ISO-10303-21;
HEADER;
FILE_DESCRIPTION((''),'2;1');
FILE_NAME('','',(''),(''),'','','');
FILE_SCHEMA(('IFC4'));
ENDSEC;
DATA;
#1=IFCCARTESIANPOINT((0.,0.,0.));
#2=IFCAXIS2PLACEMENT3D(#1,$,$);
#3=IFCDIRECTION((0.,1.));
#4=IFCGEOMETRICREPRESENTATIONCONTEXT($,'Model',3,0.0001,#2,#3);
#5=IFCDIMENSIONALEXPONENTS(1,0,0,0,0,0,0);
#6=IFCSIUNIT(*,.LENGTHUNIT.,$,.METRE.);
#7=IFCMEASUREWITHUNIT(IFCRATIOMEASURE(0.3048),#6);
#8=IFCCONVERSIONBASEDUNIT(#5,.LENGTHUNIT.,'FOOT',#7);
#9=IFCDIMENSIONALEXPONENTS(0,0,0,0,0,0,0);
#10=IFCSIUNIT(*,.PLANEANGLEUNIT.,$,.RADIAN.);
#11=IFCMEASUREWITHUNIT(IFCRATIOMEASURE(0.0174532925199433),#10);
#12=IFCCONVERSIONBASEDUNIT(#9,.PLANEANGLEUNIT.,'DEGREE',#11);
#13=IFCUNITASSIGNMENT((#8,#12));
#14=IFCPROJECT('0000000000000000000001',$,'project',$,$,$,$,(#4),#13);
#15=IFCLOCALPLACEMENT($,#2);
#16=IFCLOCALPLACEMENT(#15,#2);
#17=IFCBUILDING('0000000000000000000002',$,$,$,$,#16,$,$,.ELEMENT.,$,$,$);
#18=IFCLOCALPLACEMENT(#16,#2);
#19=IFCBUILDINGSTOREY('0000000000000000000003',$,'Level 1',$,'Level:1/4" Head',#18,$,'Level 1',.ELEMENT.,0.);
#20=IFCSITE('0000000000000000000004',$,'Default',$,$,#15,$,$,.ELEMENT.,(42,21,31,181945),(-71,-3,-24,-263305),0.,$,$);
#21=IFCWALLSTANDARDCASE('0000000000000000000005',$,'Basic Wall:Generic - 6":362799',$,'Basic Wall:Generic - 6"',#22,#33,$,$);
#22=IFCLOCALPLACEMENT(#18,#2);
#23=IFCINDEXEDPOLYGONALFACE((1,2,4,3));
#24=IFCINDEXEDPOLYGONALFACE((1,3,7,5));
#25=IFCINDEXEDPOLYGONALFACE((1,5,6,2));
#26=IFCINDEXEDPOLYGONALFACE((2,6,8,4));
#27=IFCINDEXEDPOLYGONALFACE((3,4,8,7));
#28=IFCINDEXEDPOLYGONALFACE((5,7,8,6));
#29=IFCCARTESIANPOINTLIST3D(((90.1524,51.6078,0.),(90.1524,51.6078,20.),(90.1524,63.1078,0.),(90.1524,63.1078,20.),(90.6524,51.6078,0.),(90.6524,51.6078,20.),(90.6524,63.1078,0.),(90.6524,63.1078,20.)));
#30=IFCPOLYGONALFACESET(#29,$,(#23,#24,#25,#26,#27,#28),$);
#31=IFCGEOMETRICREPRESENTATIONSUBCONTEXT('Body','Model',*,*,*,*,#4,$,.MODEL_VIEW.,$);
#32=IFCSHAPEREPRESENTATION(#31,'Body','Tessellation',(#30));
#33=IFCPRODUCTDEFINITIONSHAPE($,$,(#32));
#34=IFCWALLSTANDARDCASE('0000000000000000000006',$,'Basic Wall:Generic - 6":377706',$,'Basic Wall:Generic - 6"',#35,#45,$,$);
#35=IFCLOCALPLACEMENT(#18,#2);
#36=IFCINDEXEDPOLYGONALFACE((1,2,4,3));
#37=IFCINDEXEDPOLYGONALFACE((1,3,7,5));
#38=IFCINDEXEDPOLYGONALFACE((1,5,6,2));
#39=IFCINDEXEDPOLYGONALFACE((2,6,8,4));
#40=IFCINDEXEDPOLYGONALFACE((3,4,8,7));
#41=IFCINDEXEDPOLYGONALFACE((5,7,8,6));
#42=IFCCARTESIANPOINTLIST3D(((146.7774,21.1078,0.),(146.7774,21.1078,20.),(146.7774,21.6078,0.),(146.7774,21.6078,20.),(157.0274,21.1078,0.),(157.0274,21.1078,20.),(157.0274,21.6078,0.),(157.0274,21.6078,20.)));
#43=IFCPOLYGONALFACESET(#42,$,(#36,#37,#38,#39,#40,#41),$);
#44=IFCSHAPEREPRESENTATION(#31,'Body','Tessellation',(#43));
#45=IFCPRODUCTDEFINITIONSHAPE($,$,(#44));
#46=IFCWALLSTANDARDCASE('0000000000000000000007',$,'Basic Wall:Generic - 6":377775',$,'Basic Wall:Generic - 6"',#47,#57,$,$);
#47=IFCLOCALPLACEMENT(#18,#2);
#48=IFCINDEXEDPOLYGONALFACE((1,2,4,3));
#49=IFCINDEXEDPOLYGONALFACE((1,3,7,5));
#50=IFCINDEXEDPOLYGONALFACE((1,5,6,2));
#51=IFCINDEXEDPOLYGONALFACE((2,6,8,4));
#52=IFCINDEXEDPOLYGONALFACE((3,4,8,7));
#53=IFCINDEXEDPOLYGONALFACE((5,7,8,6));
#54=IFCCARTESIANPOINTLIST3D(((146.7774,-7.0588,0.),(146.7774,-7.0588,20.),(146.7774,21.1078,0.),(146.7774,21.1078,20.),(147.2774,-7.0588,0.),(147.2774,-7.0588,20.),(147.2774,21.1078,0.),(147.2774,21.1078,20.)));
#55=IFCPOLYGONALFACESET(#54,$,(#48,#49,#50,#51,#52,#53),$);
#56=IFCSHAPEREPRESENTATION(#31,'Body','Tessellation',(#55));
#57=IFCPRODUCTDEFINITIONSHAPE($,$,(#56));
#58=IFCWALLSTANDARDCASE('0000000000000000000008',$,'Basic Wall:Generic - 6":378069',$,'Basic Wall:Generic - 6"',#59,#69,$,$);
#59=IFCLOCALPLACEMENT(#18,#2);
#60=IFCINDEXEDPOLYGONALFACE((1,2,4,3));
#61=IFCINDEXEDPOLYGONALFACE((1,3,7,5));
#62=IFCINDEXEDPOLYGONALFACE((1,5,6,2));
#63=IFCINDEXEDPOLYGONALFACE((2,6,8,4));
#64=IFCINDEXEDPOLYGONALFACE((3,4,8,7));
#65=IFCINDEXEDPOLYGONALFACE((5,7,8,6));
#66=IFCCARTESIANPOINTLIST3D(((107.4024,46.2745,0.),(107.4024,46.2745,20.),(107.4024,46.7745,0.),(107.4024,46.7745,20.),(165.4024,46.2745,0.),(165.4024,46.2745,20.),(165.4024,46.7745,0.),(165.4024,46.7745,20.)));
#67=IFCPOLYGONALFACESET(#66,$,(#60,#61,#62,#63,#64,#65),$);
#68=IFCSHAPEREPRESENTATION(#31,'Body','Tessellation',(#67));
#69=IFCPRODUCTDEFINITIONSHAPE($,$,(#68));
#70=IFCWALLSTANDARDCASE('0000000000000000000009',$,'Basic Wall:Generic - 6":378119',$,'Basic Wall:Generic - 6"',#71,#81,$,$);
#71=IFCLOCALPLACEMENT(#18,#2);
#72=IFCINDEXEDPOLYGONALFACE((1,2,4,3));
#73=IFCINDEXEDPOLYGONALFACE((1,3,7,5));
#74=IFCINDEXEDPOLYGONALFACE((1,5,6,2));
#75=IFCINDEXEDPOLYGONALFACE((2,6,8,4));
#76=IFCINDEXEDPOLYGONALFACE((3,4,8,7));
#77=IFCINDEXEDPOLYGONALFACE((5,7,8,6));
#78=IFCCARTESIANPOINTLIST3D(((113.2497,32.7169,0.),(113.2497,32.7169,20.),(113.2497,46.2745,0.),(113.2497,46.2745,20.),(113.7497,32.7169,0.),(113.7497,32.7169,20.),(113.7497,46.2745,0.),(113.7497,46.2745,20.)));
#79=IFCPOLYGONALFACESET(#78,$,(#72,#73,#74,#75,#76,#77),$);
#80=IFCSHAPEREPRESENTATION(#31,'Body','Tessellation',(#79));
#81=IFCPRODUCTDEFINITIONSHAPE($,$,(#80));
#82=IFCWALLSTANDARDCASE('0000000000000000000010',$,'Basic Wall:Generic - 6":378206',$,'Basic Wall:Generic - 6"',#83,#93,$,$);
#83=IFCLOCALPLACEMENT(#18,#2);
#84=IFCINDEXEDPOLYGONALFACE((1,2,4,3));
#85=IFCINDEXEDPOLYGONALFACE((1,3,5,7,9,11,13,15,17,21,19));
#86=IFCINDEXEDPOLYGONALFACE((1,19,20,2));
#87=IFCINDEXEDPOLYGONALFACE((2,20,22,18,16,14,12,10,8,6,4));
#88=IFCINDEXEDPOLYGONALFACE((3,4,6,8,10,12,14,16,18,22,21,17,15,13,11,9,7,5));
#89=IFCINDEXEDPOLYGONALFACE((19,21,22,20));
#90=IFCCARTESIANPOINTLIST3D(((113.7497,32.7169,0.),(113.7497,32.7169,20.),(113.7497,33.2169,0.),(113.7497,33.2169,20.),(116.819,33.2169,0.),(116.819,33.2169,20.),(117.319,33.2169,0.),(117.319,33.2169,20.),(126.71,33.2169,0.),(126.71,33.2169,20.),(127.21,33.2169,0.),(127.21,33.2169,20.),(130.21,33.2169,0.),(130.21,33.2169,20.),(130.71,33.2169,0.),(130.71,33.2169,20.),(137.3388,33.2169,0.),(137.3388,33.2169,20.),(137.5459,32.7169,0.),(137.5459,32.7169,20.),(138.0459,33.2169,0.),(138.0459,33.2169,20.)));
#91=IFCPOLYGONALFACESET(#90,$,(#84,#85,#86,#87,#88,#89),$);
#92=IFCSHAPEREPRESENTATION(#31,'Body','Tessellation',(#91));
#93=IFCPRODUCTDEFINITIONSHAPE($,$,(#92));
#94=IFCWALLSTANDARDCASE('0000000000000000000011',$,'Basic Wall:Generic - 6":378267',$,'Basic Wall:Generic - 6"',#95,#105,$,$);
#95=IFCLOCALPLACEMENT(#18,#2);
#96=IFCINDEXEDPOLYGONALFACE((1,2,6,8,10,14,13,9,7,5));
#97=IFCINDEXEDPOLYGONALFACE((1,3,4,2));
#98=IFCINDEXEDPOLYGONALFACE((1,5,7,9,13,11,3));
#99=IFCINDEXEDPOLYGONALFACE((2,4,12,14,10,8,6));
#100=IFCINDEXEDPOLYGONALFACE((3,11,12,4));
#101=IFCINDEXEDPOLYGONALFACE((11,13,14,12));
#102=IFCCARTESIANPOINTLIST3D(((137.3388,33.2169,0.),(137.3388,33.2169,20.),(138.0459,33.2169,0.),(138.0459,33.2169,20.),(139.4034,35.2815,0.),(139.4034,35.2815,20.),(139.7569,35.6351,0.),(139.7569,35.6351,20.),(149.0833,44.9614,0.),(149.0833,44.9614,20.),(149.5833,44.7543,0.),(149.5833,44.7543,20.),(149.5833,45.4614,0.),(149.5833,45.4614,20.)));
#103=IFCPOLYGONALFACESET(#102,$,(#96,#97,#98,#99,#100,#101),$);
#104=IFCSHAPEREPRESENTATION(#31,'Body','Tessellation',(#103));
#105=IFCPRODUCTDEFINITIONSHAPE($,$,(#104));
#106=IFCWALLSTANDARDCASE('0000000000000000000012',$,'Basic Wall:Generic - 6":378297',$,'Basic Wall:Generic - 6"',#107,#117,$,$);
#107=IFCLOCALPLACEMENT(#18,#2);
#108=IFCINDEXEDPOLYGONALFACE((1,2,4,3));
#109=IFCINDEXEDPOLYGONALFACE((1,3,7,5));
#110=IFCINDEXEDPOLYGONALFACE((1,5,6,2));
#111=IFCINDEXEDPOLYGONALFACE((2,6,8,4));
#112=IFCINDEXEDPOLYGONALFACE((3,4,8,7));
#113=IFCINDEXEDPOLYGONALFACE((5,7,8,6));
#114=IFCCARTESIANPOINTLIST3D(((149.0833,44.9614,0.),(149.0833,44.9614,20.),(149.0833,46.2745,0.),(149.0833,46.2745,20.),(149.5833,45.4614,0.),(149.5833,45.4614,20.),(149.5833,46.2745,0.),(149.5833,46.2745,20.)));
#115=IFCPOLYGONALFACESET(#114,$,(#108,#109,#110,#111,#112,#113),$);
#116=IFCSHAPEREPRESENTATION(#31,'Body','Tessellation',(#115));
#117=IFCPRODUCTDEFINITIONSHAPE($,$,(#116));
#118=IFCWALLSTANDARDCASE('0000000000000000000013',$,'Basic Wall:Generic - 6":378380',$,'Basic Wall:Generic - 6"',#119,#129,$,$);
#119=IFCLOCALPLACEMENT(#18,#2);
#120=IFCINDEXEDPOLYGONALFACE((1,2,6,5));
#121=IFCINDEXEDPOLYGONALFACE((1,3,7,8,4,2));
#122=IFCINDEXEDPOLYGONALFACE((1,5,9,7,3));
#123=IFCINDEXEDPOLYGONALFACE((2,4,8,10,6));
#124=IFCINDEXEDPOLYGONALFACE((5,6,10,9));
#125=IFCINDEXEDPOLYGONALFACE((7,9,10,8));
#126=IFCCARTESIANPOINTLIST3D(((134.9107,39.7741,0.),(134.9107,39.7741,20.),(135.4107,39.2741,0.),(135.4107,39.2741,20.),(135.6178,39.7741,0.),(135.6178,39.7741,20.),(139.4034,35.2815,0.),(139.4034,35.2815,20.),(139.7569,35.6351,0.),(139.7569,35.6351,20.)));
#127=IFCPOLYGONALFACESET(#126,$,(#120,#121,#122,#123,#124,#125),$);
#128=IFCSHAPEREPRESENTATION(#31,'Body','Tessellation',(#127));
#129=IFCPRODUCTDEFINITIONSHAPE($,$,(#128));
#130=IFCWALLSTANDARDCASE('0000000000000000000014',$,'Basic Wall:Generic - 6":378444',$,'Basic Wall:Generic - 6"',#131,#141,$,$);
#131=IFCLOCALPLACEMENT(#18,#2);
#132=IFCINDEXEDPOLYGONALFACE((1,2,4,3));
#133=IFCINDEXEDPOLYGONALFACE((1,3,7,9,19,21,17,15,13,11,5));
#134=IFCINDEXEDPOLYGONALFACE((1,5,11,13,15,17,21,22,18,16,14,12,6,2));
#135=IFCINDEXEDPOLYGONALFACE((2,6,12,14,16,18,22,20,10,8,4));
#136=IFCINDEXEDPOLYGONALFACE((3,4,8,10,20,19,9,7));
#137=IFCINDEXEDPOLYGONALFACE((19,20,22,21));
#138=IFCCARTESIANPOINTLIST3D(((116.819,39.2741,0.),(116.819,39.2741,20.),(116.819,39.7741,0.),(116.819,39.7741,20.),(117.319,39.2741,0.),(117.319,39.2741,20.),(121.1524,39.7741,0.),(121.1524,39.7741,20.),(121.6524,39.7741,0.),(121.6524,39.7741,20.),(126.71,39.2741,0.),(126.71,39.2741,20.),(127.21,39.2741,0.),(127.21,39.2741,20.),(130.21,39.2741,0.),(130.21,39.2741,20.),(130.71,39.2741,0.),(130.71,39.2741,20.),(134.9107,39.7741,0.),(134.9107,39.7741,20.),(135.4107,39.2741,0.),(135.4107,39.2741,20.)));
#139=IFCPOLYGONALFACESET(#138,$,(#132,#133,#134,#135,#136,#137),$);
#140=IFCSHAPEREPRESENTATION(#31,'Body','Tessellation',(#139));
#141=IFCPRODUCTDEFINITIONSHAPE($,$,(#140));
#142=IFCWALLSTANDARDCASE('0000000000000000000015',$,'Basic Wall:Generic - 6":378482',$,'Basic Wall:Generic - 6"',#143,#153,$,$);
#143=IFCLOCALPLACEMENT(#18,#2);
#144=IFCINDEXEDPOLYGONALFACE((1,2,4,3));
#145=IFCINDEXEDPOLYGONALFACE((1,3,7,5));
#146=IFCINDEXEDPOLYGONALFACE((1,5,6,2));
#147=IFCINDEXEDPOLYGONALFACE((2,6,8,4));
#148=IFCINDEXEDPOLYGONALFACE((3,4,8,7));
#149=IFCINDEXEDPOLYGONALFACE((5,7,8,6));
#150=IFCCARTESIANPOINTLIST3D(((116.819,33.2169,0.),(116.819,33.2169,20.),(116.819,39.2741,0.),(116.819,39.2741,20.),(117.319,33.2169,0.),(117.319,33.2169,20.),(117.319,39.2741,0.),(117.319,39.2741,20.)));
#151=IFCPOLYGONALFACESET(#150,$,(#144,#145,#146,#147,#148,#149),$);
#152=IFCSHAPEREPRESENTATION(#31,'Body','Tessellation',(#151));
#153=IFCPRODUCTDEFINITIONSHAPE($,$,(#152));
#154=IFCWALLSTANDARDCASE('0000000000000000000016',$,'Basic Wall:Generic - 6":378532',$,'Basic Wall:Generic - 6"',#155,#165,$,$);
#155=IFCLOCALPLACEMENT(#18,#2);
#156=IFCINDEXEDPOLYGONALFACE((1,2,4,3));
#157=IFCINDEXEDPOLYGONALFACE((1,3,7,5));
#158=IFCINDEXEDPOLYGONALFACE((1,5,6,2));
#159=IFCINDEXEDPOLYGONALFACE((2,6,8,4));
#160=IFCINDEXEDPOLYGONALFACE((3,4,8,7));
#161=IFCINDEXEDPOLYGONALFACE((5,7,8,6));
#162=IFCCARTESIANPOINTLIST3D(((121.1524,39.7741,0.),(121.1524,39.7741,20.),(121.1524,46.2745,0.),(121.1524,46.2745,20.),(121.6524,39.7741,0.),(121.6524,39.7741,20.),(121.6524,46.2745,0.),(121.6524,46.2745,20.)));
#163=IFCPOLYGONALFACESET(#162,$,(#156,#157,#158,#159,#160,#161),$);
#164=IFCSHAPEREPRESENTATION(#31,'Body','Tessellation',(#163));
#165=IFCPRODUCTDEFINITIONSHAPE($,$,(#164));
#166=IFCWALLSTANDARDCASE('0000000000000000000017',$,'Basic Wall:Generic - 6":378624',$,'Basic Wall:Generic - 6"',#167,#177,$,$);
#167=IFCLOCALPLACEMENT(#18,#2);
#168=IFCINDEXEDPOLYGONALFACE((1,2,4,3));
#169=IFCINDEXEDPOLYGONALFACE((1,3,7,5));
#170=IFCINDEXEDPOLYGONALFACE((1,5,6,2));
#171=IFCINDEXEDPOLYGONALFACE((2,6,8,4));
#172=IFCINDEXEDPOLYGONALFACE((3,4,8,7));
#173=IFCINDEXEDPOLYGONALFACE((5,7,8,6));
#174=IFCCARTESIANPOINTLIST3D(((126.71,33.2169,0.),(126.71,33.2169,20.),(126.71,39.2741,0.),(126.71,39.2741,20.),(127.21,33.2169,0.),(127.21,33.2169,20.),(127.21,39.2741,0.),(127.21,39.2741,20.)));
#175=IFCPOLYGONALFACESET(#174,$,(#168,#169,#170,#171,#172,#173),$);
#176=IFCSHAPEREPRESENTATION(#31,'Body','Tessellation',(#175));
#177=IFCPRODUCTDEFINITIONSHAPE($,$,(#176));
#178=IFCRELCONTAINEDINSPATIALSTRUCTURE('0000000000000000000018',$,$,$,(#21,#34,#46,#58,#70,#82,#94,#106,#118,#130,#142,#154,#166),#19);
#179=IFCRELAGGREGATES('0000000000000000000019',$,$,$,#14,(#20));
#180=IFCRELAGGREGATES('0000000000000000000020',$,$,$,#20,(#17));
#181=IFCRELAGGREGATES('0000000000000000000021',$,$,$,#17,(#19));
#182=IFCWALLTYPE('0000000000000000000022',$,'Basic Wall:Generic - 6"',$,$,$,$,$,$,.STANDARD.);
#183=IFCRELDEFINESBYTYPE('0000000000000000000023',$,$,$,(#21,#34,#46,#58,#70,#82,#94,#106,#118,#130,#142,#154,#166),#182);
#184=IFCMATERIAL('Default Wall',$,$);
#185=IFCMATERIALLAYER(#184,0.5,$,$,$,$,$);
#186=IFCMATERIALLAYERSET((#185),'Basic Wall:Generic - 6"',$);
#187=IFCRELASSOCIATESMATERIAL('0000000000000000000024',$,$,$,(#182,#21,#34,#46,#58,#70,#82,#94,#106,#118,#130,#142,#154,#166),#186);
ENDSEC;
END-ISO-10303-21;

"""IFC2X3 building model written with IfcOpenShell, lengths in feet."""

from ifc_helpers import new_model, entity, si_unit, converted_unit, direction, frame, frame_2d, origin, place, context, subcontext, project, spatial, polyline, rectangle, outline, extrude, material, layer, layer_set, layer_usage, type_object, element, save


model = new_model("IFC2X3")

# Units and contexts
model_context = context("Model", 3, precision=0.0001, world=origin(), true_north=direction((0.0, 1.0)))
body_context = subcontext(model_context, "Body", "Model", "MODEL_VIEW")
ifc_project = project(units=[converted_unit("LENGTHUNIT", "FOOT", entity("IfcRatioMeasure", 0.3048), si_unit("LENGTHUNIT", "METRE"), dimensions=[1, 0, 0, 0, 0, 0, 0]), converted_unit("PLANEANGLEUNIT", "DEGREE", entity("IfcRatioMeasure", 0.0174532925199433), si_unit("PLANEANGLEUNIT", "RADIAN"), dimensions=[0, 0, 0, 0, 0, 0, 0])], contexts=[model_context])

# Site, building, storey
site_placement = place(None, origin())
site = spatial("IfcSite", under=ifc_project, at=site_placement, Name="Default", CompositionType="ELEMENT", RefLatitude=(42, 21, 31, 181945), RefLongitude=(-71, -3, -24, -263305), RefElevation=0.0)
building_placement = place(site_placement, origin())
building = spatial("IfcBuilding", under=site, at=building_placement, CompositionType="ELEMENT")
storey_placement = place(building_placement, origin())
storey = spatial("IfcBuildingStorey", under=building, at=storey_placement, Name="Level 1", ObjectType="Level:1/4\" Head", LongName="Level 1", CompositionType="ELEMENT", Elevation=0.0)

# Walls
ifc_material = material(Name="Default Wall")
ifc_layer_1 = layer(ifc_material, 0.5)
ifc_layer_set_1 = layer_set([ifc_layer_1], Name="Basic Wall:Generic - 6\"")
wall_type_1 = type_object("IfcWallType", Name="Basic Wall:Generic - 6\"", PredefinedType="STANDARD", material=ifc_layer_set_1)
ifc_layer_usage_1 = layer_usage(ifc_layer_set_1, "AXIS2", "NEGATIVE", 0.25)
wall_1_placement = place(storey_placement, frame((90.4024, 63.1078, 0.0), z_axis=(0.0, 0.0, 1.0), x_axis=(0.0, -1.0, 0.0)))
element("IfcWallStandardCase", 1, at=wall_1_placement, inside=storey, type_object=wall_type_1, material=ifc_layer_usage_1, Name="Basic Wall:Generic - 6\":362799", ObjectType="Basic Wall:Generic - 6\"", context=body_context, shape_type="SweptSolid", body=[
    extrude(rectangle(XDim=11.5, YDim=0.5, at=frame_2d((5.75, 0.0), x_axis=(-1.0, 0.0))), origin(), (0.0, 0.0, 1.0), 20.0),
])
ifc_layer_usage_2 = layer_usage(ifc_layer_set_1, "AXIS2", "NEGATIVE", 0.25)
wall_2_placement = place(storey_placement, frame((157.0274, 21.3578, 0.0), z_axis=(0.0, 0.0, 1.0), x_axis=(-1.0, 0.0, 0.0)))
element("IfcWallStandardCase", 2, at=wall_2_placement, inside=storey, type_object=wall_type_1, material=ifc_layer_usage_2, Name="Basic Wall:Generic - 6\":377706", ObjectType="Basic Wall:Generic - 6\"", context=body_context, shape_type="SweptSolid", body=[
    extrude(rectangle(XDim=10.25, YDim=0.5, at=frame_2d((5.125, 0.0), x_axis=(-1.0, 0.0))), origin(), (0.0, 0.0, 1.0), 20.0),
])
ifc_layer_usage_3 = layer_usage(ifc_layer_set_1, "AXIS2", "NEGATIVE", 0.25)
wall_3_placement = place(storey_placement, frame((147.0274, 21.1078, 0.0), z_axis=(0.0, 0.0, 1.0), x_axis=(0.0, -1.0, 0.0)))
element("IfcWallStandardCase", 3, at=wall_3_placement, inside=storey, type_object=wall_type_1, material=ifc_layer_usage_3, Name="Basic Wall:Generic - 6\":377775", ObjectType="Basic Wall:Generic - 6\"", context=body_context, shape_type="SweptSolid", body=[
    extrude(rectangle(XDim=28.1667, YDim=0.5, at=frame_2d((14.0833, 0.0), x_axis=(-1.0, 0.0))), origin(), (0.0, 0.0, 1.0), 20.0),
])
ifc_layer_usage_4 = layer_usage(ifc_layer_set_1, "AXIS2", "NEGATIVE", 0.25)
wall_4_placement = place(storey_placement, frame((165.4024, 46.5245, 0.0), z_axis=(0.0, 0.0, 1.0), x_axis=(-1.0, 0.0, 0.0)))
element("IfcWallStandardCase", 4, at=wall_4_placement, inside=storey, type_object=wall_type_1, material=ifc_layer_usage_4, Name="Basic Wall:Generic - 6\":378069", ObjectType="Basic Wall:Generic - 6\"", context=body_context, shape_type="SweptSolid", body=[
    extrude(rectangle(XDim=58.0, YDim=0.5, at=frame_2d((29.0, 0.0), x_axis=(-1.0, 0.0))), origin(), (0.0, 0.0, 1.0), 20.0),
])
ifc_layer_usage_5 = layer_usage(ifc_layer_set_1, "AXIS2", "NEGATIVE", 0.25)
wall_5_placement = place(storey_placement, frame((113.4997, 46.2745, 0.0), z_axis=(0.0, 0.0, 1.0), x_axis=(0.0, -1.0, 0.0)))
element("IfcWallStandardCase", 5, at=wall_5_placement, inside=storey, type_object=wall_type_1, material=ifc_layer_usage_5, Name="Basic Wall:Generic - 6\":378119", ObjectType="Basic Wall:Generic - 6\"", context=body_context, shape_type="SweptSolid", body=[
    extrude(rectangle(XDim=13.5576, YDim=0.5, at=frame_2d((6.7788, 0.0), x_axis=(-1.0, 0.0))), origin(), (0.0, 0.0, 1.0), 20.0),
])
ifc_layer_usage_6 = layer_usage(ifc_layer_set_1, "AXIS2", "NEGATIVE", 0.25)
wall_6_placement = place(storey_placement, frame((113.7497, 32.9669, 0.0)))
element("IfcWallStandardCase", 6, at=wall_6_placement, inside=storey, type_object=wall_type_1, material=ifc_layer_usage_6, Name="Basic Wall:Generic - 6\":378206", ObjectType="Basic Wall:Generic - 6\"", context=body_context, shape_type="SweptSolid", body=[
    extrude(outline(polyline([(23.7962, -0.25), (24.2962, 0.25), (23.5891, 0.25), (16.9603, 0.25), (16.4603, 0.25), (13.4603, 0.25), (12.9603, 0.25), (3.5693, 0.25), (3.0693, 0.25), (0.0, 0.25), (0.0, -0.25), (23.7962, -0.25)])), origin(), (0.0, 0.0, 1.0), 20.0),
])
ifc_layer_usage_7 = layer_usage(ifc_layer_set_1, "AXIS2", "NEGATIVE", 0.25)
wall_7_placement = place(storey_placement, frame((137.5155, 33.0401, 0.0), z_axis=(0.0, 0.0, 1.0), x_axis=(0.707107, 0.707107, 0.0)))
element("IfcWallStandardCase", 7, at=wall_7_placement, inside=storey, type_object=wall_type_1, material=ifc_layer_usage_7, Name="Basic Wall:Generic - 6\":378267", ObjectType="Basic Wall:Generic - 6\"", context=body_context, shape_type="SweptSolid", body=[
    extrude(outline(polyline([(16.8163, -0.25), (17.3163, 0.25), (16.6092, 0.25), (3.4198, 0.25), (2.9198, 0.25), (0.0, 0.25), (0.5, -0.25), (16.8163, -0.25)])), origin(), (0.0, 0.0, 1.0), 20.0),
])
ifc_layer_usage_8 = layer_usage(ifc_layer_set_1, "AXIS2", "NEGATIVE", 0.25)
wall_8_placement = place(storey_placement, frame((149.3333, 44.9614, 0.0), z_axis=(0.0, 0.0, 1.0), x_axis=(0.0, 1.0, 0.0)))
element("IfcWallStandardCase", 8, at=wall_8_placement, inside=storey, type_object=wall_type_1, material=ifc_layer_usage_8, Name="Basic Wall:Generic - 6\":378297", ObjectType="Basic Wall:Generic - 6\"", context=body_context, shape_type="SweptSolid", body=[
    extrude(outline(polyline([(1.3131, -0.25), (1.3131, 0.25), (0.0, 0.25), (0.5, -0.25), (1.3131, -0.25)])), origin(), (0.0, 0.0, 1.0), 20.0),
])
ifc_layer_usage_9 = layer_usage(ifc_layer_set_1, "AXIS2", "NEGATIVE", 0.25)
wall_9_placement = place(storey_placement, frame((139.5802, 35.4583, 0.0), z_axis=(0.0, 0.0, 1.0), x_axis=(-0.707107, 0.707107, 0.0)))
element("IfcWallStandardCase", 9, at=wall_9_placement, inside=storey, type_object=wall_type_1, material=ifc_layer_usage_9, Name="Basic Wall:Generic - 6\":378380", ObjectType="Basic Wall:Generic - 6\"", context=body_context, shape_type="SweptSolid", body=[
    extrude(outline(polyline([(5.8536, -0.25), (6.3536, 0.25), (5.6464, 0.25), (0.0, 0.25), (0.0, -0.25), (5.8536, -0.25)])), origin(), (0.0, 0.0, 1.0), 20.0),
])
ifc_layer_usage_10 = layer_usage(ifc_layer_set_1, "AXIS2", "NEGATIVE", 0.25)
wall_10_placement = place(storey_placement, frame((135.4107, 39.5241, 0.0), z_axis=(0.0, 0.0, 1.0), x_axis=(-1.0, 0.0, 0.0)))
element("IfcWallStandardCase", 10, at=wall_10_placement, inside=storey, type_object=wall_type_1, material=ifc_layer_usage_10, Name="Basic Wall:Generic - 6\":378444", ObjectType="Basic Wall:Generic - 6\"", context=body_context, shape_type="SweptSolid", body=[
    extrude(outline(polyline([(18.5917, -0.25), (18.5917, 0.25), (18.0917, 0.25), (8.7008, 0.25), (8.2008, 0.25), (5.2008, 0.25), (4.7008, 0.25), (0.0, 0.25), (0.5, -0.25), (13.7584, -0.25), (14.2584, -0.25), (18.5917, -0.25)])), origin(), (0.0, 0.0, 1.0), 20.0),
])
ifc_layer_usage_11 = layer_usage(ifc_layer_set_1, "AXIS2", "NEGATIVE", 0.25)
wall_11_placement = place(storey_placement, frame((117.069, 39.2741, 0.0), z_axis=(0.0, 0.0, 1.0), x_axis=(0.0, -1.0, 0.0)))
element("IfcWallStandardCase", 11, at=wall_11_placement, inside=storey, type_object=wall_type_1, material=ifc_layer_usage_11, Name="Basic Wall:Generic - 6\":378482", ObjectType="Basic Wall:Generic - 6\"", context=body_context, shape_type="SweptSolid", body=[
    extrude(rectangle(XDim=6.0572, YDim=0.5, at=frame_2d((3.0286, 0.0), x_axis=(-1.0, 0.0))), origin(), (0.0, 0.0, 1.0), 20.0),
])
ifc_layer_usage_12 = layer_usage(ifc_layer_set_1, "AXIS2", "NEGATIVE", 0.25)
wall_12_placement = place(storey_placement, frame((121.4024, 39.7741, 0.0), z_axis=(0.0, 0.0, 1.0), x_axis=(0.0, 1.0, 0.0)))
element("IfcWallStandardCase", 12, at=wall_12_placement, inside=storey, type_object=wall_type_1, material=ifc_layer_usage_12, Name="Basic Wall:Generic - 6\":378532", ObjectType="Basic Wall:Generic - 6\"", context=body_context, shape_type="SweptSolid", body=[
    extrude(rectangle(XDim=6.5004, YDim=0.5, at=frame_2d((3.2502, 0.0), x_axis=(-1.0, 0.0))), origin(), (0.0, 0.0, 1.0), 20.0),
])
ifc_layer_usage_13 = layer_usage(ifc_layer_set_1, "AXIS2", "NEGATIVE", 0.25)
wall_13_placement = place(storey_placement, frame((126.96, 33.2169, 0.0), z_axis=(0.0, 0.0, 1.0), x_axis=(0.0, 1.0, 0.0)))
element("IfcWallStandardCase", 13, at=wall_13_placement, inside=storey, type_object=wall_type_1, material=ifc_layer_usage_13, Name="Basic Wall:Generic - 6\":378624", ObjectType="Basic Wall:Generic - 6\"", context=body_context, shape_type="SweptSolid", body=[
    extrude(rectangle(XDim=6.0572, YDim=0.5, at=frame_2d((3.0286, 0.0), x_axis=(-1.0, 0.0))), origin(), (0.0, 0.0, 1.0), 20.0),
])

save(model, "model.ifc")
